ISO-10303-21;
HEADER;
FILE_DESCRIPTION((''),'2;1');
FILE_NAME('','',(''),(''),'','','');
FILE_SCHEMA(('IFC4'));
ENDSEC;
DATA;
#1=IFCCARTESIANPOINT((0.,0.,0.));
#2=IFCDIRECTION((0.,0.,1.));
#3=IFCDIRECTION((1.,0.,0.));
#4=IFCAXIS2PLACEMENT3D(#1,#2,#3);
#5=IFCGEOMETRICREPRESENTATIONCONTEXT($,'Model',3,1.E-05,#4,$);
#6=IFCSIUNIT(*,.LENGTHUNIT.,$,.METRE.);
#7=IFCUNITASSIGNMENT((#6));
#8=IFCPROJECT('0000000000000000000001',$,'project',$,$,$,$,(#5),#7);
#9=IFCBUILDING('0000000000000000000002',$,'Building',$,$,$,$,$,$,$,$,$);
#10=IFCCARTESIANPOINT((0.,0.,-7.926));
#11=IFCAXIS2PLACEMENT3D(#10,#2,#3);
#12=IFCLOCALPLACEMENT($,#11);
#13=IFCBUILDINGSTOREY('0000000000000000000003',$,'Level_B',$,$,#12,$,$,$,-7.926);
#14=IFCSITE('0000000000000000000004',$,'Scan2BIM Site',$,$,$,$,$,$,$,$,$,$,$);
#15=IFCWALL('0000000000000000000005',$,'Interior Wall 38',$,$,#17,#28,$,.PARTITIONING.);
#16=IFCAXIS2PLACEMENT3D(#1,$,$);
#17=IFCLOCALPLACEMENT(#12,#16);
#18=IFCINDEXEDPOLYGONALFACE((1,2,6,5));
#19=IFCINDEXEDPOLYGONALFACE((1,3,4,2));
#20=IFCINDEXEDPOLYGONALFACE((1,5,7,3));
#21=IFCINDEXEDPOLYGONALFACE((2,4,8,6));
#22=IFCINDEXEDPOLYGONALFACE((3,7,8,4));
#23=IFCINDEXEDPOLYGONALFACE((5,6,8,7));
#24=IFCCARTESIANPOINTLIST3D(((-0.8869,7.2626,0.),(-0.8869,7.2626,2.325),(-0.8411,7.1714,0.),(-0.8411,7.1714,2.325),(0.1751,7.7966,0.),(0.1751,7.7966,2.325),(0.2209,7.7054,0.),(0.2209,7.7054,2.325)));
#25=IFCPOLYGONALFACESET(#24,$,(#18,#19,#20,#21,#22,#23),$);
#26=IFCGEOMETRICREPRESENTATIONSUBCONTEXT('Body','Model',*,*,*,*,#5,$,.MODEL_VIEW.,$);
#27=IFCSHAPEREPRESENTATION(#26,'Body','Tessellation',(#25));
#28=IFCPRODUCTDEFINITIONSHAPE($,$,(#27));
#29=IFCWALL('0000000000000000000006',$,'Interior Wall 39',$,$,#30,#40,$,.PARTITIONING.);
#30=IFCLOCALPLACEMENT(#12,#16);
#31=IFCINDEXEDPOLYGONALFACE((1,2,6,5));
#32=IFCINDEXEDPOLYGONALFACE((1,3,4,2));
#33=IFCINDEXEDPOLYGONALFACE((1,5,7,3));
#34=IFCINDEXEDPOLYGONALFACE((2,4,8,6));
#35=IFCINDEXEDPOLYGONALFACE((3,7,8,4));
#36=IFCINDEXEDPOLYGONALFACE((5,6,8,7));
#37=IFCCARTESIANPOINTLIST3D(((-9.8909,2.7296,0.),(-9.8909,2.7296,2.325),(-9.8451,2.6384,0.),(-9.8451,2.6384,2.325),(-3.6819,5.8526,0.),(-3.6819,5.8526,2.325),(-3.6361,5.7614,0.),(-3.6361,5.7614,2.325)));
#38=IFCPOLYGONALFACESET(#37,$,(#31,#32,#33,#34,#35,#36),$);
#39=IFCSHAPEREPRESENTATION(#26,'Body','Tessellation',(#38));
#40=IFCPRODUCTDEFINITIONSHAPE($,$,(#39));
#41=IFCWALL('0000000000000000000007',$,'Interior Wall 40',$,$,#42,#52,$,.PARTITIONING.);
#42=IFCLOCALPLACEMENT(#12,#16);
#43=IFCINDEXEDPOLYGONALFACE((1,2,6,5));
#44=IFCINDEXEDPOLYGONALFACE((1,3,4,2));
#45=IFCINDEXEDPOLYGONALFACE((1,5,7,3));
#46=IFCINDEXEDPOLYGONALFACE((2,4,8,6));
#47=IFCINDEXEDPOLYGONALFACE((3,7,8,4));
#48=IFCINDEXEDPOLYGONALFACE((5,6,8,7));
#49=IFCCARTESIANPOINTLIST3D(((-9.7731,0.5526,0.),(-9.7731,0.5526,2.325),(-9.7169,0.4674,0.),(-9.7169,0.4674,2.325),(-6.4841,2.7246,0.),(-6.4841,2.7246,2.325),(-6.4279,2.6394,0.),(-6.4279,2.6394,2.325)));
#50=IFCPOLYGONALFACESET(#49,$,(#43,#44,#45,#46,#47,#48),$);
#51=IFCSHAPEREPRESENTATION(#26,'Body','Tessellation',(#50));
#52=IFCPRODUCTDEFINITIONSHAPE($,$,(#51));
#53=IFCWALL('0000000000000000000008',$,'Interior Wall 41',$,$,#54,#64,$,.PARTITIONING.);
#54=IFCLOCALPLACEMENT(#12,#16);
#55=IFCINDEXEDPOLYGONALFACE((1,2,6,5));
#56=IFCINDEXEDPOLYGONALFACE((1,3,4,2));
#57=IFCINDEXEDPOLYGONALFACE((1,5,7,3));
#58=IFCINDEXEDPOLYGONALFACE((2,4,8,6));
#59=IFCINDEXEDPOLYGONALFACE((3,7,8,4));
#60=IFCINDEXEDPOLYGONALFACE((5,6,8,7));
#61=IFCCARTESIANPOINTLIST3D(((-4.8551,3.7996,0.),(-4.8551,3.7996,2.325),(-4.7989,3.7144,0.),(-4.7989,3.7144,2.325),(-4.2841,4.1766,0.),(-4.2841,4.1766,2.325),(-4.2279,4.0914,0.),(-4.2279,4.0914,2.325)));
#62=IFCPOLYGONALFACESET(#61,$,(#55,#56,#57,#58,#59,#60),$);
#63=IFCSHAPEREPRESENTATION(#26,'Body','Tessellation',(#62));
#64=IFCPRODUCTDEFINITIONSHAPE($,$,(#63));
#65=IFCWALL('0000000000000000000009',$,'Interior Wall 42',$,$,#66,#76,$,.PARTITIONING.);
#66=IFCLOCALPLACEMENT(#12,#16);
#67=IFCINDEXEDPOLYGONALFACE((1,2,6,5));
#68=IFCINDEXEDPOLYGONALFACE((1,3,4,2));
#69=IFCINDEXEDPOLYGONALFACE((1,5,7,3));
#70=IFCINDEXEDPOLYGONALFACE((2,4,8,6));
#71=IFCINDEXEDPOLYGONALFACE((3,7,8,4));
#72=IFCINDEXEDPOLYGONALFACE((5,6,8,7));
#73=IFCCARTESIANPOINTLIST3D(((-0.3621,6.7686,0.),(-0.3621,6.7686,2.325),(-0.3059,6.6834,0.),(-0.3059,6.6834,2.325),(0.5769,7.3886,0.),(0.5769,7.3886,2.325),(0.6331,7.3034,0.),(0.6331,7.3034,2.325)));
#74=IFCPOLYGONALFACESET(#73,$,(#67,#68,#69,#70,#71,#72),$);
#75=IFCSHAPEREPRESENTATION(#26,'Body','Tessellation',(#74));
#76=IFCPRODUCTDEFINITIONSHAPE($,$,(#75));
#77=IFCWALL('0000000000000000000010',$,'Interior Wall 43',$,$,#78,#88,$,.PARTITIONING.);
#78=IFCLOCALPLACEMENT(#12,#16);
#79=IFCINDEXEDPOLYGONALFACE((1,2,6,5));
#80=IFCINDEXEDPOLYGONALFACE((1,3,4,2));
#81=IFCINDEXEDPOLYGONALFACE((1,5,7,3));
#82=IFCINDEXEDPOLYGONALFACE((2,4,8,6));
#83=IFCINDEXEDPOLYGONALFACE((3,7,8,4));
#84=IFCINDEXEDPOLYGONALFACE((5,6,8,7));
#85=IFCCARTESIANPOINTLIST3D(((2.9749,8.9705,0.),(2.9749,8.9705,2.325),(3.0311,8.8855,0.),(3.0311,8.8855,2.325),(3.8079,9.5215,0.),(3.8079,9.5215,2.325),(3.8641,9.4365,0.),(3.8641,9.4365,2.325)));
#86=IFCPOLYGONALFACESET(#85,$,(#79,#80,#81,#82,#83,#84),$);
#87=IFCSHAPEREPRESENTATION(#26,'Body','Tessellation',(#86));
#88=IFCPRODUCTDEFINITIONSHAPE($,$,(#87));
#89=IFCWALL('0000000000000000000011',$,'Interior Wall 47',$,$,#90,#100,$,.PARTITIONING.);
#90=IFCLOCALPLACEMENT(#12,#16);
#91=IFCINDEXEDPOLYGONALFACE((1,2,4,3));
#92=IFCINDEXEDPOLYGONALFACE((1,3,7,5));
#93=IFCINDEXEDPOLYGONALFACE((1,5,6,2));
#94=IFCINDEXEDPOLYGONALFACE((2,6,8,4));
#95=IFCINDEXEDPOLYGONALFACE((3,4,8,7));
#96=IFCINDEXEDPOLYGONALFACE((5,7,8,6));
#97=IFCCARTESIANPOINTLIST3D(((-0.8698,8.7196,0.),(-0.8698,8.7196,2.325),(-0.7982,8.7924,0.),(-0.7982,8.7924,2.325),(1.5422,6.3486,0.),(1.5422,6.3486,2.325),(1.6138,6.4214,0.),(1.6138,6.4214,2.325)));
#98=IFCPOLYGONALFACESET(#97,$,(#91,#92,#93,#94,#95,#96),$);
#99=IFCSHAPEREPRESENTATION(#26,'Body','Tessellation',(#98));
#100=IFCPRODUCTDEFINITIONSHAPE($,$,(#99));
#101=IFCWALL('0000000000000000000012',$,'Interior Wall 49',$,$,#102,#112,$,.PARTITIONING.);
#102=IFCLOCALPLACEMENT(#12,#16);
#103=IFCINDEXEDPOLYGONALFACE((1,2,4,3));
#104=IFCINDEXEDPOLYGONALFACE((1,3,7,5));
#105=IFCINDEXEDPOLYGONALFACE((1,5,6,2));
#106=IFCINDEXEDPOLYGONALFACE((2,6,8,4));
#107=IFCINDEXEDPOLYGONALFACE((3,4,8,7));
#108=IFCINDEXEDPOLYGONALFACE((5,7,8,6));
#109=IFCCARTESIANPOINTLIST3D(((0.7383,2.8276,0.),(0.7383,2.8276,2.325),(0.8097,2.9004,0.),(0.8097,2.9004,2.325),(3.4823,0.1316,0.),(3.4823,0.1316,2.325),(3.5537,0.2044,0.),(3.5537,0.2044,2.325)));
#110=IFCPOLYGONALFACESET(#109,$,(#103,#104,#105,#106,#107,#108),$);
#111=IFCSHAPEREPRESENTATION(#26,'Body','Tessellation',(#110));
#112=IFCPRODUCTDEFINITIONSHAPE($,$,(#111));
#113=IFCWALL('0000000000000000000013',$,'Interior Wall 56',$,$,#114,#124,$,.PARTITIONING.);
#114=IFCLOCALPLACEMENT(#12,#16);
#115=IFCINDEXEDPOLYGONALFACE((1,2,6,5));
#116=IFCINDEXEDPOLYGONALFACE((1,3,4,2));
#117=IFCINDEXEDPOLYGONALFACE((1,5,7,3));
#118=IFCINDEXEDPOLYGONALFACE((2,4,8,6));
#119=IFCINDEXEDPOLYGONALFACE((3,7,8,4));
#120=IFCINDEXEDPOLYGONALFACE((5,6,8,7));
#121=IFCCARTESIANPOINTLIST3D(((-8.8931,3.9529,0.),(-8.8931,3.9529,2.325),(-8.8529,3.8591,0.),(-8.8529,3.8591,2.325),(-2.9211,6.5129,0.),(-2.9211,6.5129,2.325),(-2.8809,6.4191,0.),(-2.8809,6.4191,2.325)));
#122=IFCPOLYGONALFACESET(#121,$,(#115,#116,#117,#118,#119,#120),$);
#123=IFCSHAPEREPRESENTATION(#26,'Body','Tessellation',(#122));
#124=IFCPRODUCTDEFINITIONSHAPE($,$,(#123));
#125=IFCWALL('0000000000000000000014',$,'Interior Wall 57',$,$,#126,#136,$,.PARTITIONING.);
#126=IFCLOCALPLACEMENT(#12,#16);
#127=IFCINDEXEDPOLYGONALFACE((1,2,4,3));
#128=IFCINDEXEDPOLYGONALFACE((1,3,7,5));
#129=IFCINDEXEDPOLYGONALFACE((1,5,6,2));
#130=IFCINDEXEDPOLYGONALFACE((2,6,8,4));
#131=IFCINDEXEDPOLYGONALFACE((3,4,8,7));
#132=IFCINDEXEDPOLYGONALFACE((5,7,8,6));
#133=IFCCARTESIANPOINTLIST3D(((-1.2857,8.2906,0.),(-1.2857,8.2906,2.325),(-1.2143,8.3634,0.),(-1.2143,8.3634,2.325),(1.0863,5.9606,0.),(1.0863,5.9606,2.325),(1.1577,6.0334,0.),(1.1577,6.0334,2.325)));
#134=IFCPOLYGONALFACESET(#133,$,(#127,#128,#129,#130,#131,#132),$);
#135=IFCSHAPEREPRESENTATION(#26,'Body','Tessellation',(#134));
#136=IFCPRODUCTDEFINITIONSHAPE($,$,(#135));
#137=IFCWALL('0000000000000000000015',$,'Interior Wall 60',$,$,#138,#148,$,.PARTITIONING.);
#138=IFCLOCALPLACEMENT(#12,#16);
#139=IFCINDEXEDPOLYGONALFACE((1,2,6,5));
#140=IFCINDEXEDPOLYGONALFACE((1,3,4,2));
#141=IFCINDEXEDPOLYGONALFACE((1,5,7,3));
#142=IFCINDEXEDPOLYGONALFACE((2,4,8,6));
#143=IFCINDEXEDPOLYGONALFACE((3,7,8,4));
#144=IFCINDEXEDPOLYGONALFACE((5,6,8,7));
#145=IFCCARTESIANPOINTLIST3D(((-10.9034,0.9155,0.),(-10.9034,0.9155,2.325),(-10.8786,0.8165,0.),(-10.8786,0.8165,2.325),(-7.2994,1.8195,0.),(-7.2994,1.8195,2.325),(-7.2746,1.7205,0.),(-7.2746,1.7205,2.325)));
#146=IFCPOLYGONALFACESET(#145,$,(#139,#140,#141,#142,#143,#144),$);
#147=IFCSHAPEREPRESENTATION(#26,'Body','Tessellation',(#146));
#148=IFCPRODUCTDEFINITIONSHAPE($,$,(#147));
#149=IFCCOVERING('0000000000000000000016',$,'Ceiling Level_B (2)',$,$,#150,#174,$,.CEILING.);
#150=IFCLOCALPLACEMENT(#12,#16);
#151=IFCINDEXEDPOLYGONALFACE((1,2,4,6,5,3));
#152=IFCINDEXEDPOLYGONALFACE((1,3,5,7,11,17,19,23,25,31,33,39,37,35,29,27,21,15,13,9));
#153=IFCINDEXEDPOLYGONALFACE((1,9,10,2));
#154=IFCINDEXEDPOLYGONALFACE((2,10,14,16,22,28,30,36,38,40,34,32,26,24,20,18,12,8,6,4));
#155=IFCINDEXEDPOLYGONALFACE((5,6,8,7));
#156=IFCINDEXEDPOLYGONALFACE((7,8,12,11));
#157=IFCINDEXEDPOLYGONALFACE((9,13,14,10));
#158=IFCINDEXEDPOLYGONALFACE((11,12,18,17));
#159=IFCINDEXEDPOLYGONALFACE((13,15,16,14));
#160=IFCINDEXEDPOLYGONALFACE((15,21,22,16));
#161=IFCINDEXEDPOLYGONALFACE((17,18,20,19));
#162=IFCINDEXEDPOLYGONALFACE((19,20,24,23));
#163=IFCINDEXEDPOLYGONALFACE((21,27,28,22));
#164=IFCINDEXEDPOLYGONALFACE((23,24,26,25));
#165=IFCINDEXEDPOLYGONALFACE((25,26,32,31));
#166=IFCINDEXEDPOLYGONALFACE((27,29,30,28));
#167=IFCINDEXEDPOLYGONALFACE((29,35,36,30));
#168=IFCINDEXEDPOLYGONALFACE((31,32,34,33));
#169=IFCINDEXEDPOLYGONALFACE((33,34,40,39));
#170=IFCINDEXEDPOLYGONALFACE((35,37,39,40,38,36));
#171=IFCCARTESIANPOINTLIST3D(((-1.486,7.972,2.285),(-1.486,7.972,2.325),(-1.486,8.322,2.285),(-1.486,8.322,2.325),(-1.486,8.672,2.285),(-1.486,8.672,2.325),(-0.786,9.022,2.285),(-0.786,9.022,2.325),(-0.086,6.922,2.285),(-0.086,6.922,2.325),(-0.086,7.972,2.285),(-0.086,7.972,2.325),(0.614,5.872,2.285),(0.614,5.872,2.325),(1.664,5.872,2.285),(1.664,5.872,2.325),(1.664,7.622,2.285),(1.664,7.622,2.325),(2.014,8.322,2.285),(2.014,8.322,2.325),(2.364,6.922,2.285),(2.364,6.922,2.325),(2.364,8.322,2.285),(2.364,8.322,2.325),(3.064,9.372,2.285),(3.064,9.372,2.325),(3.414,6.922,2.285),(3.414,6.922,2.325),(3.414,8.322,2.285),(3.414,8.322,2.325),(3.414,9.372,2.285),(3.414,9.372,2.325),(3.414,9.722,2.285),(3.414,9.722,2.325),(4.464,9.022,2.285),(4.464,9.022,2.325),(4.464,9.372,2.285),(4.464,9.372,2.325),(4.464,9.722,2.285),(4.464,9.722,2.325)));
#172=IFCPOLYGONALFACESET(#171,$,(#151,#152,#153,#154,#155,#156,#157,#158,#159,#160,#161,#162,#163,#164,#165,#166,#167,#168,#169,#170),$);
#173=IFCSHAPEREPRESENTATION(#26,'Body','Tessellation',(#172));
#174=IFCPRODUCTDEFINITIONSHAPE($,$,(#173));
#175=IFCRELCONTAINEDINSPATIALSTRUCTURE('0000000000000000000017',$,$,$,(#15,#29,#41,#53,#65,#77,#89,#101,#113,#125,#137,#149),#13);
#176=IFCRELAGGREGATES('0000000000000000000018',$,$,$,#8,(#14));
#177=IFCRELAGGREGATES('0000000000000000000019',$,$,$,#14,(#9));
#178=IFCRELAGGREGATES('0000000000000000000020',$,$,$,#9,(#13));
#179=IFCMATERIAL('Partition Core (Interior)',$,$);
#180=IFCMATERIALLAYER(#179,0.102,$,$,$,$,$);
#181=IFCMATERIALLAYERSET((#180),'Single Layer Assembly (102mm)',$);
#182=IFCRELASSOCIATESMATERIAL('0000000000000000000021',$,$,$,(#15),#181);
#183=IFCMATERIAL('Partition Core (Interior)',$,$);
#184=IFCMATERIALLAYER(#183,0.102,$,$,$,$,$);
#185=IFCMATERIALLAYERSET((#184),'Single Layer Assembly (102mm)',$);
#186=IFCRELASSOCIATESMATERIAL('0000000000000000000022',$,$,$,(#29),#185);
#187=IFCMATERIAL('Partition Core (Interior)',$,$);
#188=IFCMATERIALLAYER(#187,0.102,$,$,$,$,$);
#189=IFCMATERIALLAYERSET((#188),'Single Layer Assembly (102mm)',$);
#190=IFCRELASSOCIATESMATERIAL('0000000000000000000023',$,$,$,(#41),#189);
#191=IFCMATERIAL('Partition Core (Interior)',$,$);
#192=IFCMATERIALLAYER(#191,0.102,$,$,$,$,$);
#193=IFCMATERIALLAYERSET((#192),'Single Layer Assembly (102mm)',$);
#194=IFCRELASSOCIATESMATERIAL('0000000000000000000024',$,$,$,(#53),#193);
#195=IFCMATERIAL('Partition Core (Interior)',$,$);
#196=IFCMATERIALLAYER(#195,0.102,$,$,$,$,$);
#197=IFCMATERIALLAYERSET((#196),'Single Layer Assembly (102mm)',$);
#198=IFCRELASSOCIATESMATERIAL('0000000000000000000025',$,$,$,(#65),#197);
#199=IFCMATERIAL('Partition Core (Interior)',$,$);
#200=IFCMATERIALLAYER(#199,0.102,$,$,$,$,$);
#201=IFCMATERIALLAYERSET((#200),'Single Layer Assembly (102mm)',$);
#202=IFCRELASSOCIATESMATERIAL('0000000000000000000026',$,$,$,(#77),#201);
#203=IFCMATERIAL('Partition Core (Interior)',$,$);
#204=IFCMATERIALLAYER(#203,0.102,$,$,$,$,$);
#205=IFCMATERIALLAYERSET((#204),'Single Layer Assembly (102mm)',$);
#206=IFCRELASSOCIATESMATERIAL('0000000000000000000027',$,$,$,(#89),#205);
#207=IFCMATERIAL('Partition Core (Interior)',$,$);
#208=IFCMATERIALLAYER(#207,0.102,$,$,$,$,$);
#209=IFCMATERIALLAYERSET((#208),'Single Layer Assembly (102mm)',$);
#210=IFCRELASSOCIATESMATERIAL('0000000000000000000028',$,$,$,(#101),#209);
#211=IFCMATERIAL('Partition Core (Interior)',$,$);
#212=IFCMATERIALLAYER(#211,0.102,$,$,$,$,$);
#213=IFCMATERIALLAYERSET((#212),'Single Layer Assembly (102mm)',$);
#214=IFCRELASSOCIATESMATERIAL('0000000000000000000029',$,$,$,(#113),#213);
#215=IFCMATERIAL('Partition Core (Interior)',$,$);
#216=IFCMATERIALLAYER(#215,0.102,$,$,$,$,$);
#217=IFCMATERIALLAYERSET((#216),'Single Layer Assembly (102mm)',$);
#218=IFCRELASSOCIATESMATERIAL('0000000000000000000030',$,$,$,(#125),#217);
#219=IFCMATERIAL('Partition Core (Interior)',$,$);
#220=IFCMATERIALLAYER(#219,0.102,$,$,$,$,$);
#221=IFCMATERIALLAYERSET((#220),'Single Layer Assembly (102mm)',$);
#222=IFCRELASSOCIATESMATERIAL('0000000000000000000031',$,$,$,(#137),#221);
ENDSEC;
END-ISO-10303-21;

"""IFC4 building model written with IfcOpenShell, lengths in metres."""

from ifc_helpers import new_model, si_unit, frame, origin, origin_with_axes, place, context, subcontext, project, spatial, polyline, rectangle, outline, extrude, material, layer, layer_set, element, save


model = new_model("IFC4")

# Units and contexts
model_context = context("Model", 3, precision=1e-05, world=origin_with_axes())
body_context = subcontext(model_context, "Body", "Model", "MODEL_VIEW")
ifc_project = project(units=[si_unit("LENGTHUNIT", "METRE")], contexts=[model_context])

# Site, building, storey
site = spatial("IfcSite", under=ifc_project, Name="Scan2BIM Site")
building = spatial("IfcBuilding", under=site, Name="Building")
storey_placement = place(None, frame((0.0, 0.0, -7.926), z_axis=(0.0, 0.0, 1.0), x_axis=(1.0, 0.0, 0.0)))
storey = spatial("IfcBuildingStorey", under=building, at=storey_placement, Name="Level_B", Elevation=-7.926)

# Walls
ifc_material_1 = material(Name="Partition Core (Interior)")
ifc_layer_1 = layer(ifc_material_1, 0.102)
ifc_layer_set_1 = layer_set([ifc_layer_1], Name="Single Layer Assembly (102mm)")
wall_1_placement = place(storey_placement, frame((-0.333, 7.484, 0.0), z_axis=(0.0, 0.0, 1.0), x_axis=(-0.893415, -0.449231, 0.0)))
element("IfcWall", 1, at=wall_1_placement, inside=storey, material=ifc_layer_set_1, Name="Interior Wall 38", PredefinedType="PARTITIONING", context=body_context, shape_type="SweptSolid", body=[
    extrude(rectangle(XDim=1.1887, YDim=0.102), origin(), (0.0, 0.0, 1.0), 2.325),
])
ifc_material_2 = material(Name="Partition Core (Interior)")
ifc_layer_2 = layer(ifc_material_2, 0.102)
ifc_layer_set_2 = layer_set([ifc_layer_2], Name="Single Layer Assembly (102mm)")
wall_2_placement = place(storey_placement, frame((-6.7635, 4.2455, 0.0), z_axis=(0.0, 0.0, 1.0), x_axis=(-0.89336, -0.449342, 0.0)))
element("IfcWall", 2, at=wall_2_placement, inside=storey, material=ifc_layer_set_2, Name="Interior Wall 39", PredefinedType="PARTITIONING", context=body_context, shape_type="SweptSolid", body=[
    extrude(rectangle(XDim=6.9502, YDim=0.102), origin(), (0.0, 0.0, 1.0), 2.325),
])
ifc_material_3 = material(Name="Partition Core (Interior)")
ifc_layer_3 = layer(ifc_material_3, 0.102)
ifc_layer_set_3 = layer_set([ifc_layer_3], Name="Single Layer Assembly (102mm)")
wall_3_placement = place(storey_placement, frame((-8.1005, 1.596, 0.0), z_axis=(0.0, 0.0, 1.0), x_axis=(0.834462, 0.551065, 0.0)))
element("IfcWall", 3, at=wall_3_placement, inside=storey, material=ifc_layer_set_3, Name="Interior Wall 40", PredefinedType="PARTITIONING", context=body_context, shape_type="SweptSolid", body=[
    extrude(rectangle(XDim=3.9415, YDim=0.102), origin(), (0.0, 0.0, 1.0), 2.325),
])
ifc_material_4 = material(Name="Partition Core (Interior)")
ifc_layer_4 = layer(ifc_material_4, 0.102)
ifc_layer_set_4 = layer_set([ifc_layer_4], Name="Single Layer Assembly (102mm)")
wall_4_placement = place(storey_placement, frame((-4.5415, 3.9455, 0.0), z_axis=(0.0, 0.0, 1.0), x_axis=(0.834515, 0.550985, 0.0)))
element("IfcWall", 4, at=wall_4_placement, inside=storey, material=ifc_layer_set_4, Name="Interior Wall 41", PredefinedType="PARTITIONING", context=body_context, shape_type="SweptSolid", body=[
    extrude(rectangle(XDim=0.6842, YDim=0.102), origin(), (0.0, 0.0, 1.0), 2.325),
])
ifc_material_5 = material(Name="Partition Core (Interior)")
ifc_layer_5 = layer(ifc_material_5, 0.102)
ifc_layer_set_5 = layer_set([ifc_layer_5], Name="Single Layer Assembly (102mm)")
wall_5_placement = place(storey_placement, frame((0.1355, 7.036, 0.0), z_axis=(0.0, 0.0, 1.0), x_axis=(0.834503, 0.551003, 0.0)))
element("IfcWall", 5, at=wall_5_placement, inside=storey, material=ifc_layer_set_5, Name="Interior Wall 42", PredefinedType="PARTITIONING", context=body_context, shape_type="SweptSolid", body=[
    extrude(rectangle(XDim=1.1252, YDim=0.102), origin(), (0.0, 0.0, 1.0), 2.325),
])
ifc_material_6 = material(Name="Partition Core (Interior)")
ifc_layer_6 = layer(ifc_material_6, 0.102)
ifc_layer_set_6 = layer_set([ifc_layer_6], Name="Single Layer Assembly (102mm)")
wall_6_placement = place(storey_placement, frame((3.4195, 9.2035, 0.0), z_axis=(0.0, 0.0, 1.0), x_axis=(0.834047, 0.551693, 0.0)))
element("IfcWall", 6, at=wall_6_placement, inside=storey, material=ifc_layer_set_6, Name="Interior Wall 43", PredefinedType="PARTITIONING", context=body_context, shape_type="SweptSolid", body=[
    extrude(rectangle(XDim=0.9987, YDim=0.102), origin(), (0.0, 0.0, 1.0), 2.325),
])
ifc_material_7 = material(Name="Partition Core (Interior)")
ifc_layer_7 = layer(ifc_material_7, 0.102)
ifc_layer_set_7 = layer_set([ifc_layer_7], Name="Single Layer Assembly (102mm)")
wall_7_placement = place(storey_placement, frame((0.372, 7.5705, 0.0), z_axis=(0.0, 0.0, 1.0), x_axis=(0.713142, -0.70102, 0.0)))
element("IfcWall", 7, at=wall_7_placement, inside=storey, material=ifc_layer_set_7, Name="Interior Wall 47", PredefinedType="PARTITIONING", context=body_context, shape_type="SweptSolid", body=[
    extrude(rectangle(XDim=3.3822, YDim=0.102), origin(), (0.0, 0.0, 1.0), 2.325),
])
ifc_material_8 = material(Name="Partition Core (Interior)")
ifc_layer_8 = layer(ifc_material_8, 0.102)
ifc_layer_set_8 = layer_set([ifc_layer_8], Name="Single Layer Assembly (102mm)")
wall_8_placement = place(storey_placement, frame((2.146, 1.516, 0.0), z_axis=(0.0, 0.0, 1.0), x_axis=(-0.713318, 0.70084, 0.0)))
element("IfcWall", 8, at=wall_8_placement, inside=storey, material=ifc_layer_set_8, Name="Interior Wall 49", PredefinedType="PARTITIONING", context=body_context, shape_type="SweptSolid", body=[
    extrude(rectangle(XDim=3.8468, YDim=0.102), origin(), (0.0, 0.0, 1.0), 2.325),
])
ifc_material_9 = material(Name="Partition Core (Interior)")
ifc_layer_9 = layer(ifc_material_9, 0.102)
ifc_layer_set_9 = layer_set([ifc_layer_9], Name="Single Layer Assembly (102mm)")
wall_9_placement = place(storey_placement, frame((-5.887, 5.186, 0.0), z_axis=(0.0, 0.0, 1.0), x_axis=(-0.919113, -0.393994, 0.0)))
element("IfcWall", 9, at=wall_9_placement, inside=storey, material=ifc_layer_set_9, Name="Interior Wall 56", PredefinedType="PARTITIONING", context=body_context, shape_type="SweptSolid", body=[
    extrude(rectangle(XDim=6.4976, YDim=0.102), origin(), (0.0, 0.0, 1.0), 2.325),
])
ifc_material_10 = material(Name="Partition Core (Interior)")
ifc_layer_10 = layer(ifc_material_10, 0.102)
ifc_layer_set_10 = layer_set([ifc_layer_10], Name="Single Layer Assembly (102mm)")
wall_10_placement = place(storey_placement, frame((-0.064, 7.162, 0.0), z_axis=(0.0, 0.0, 1.0), x_axis=(-0.713394, 0.700763, 0.0)))
element("IfcWall", 10, at=wall_10_placement, inside=storey, material=ifc_layer_set_10, Name="Interior Wall 57", PredefinedType="PARTITIONING", context=body_context, shape_type="SweptSolid", body=[
    extrude(rectangle(XDim=3.3249, YDim=0.102), origin(), (0.0, 0.0, 1.0), 2.325),
])
ifc_material_11 = material(Name="Partition Core (Interior)")
ifc_layer_11 = layer(ifc_material_11, 0.102)
ifc_layer_set_11 = layer_set([ifc_layer_11], Name="Single Layer Assembly (102mm)")
wall_11_placement = place(storey_placement, frame((-9.089, 1.318, 0.0), z_axis=(0.0, 0.0, 1.0), x_axis=(0.969952, 0.243295, 0.0)))
element("IfcWall", 11, at=wall_11_placement, inside=storey, material=ifc_layer_set_11, Name="Interior Wall 60", PredefinedType="PARTITIONING", context=body_context, shape_type="SweptSolid", body=[
    extrude(rectangle(XDim=3.7156, YDim=0.102), origin(), (0.0, 0.0, 1.0), 2.325),
])

# Covering
covering_1_placement = place(storey_placement, frame((0.0, 0.0, 2.285), z_axis=(0.0, 0.0, 1.0), x_axis=(1.0, 0.0, 0.0)))
element("IfcCovering", 12, at=covering_1_placement, inside=storey, Name="Ceiling Level_B (2)", PredefinedType="CEILING", context=body_context, shape_type="SweptSolid", body=[
    extrude(outline(polyline([(0.614, 5.872), (1.664, 5.872), (2.364, 6.922), (3.414, 6.922), (3.414, 8.322), (4.464, 9.022), (4.464, 9.372), (4.464, 9.722), (3.414, 9.722), (3.414, 9.372), (3.064, 9.372), (2.364, 8.322), (2.014, 8.322), (1.664, 7.622), (-0.086, 7.972), (-0.786, 9.022), (-1.486, 8.672), (-1.486, 8.322), (-1.486, 7.972), (-0.086, 6.922), (0.614, 5.872)])), origin(), (0.0, 0.0, 1.0), 0.04),
])

save(model, "model.ifc")
